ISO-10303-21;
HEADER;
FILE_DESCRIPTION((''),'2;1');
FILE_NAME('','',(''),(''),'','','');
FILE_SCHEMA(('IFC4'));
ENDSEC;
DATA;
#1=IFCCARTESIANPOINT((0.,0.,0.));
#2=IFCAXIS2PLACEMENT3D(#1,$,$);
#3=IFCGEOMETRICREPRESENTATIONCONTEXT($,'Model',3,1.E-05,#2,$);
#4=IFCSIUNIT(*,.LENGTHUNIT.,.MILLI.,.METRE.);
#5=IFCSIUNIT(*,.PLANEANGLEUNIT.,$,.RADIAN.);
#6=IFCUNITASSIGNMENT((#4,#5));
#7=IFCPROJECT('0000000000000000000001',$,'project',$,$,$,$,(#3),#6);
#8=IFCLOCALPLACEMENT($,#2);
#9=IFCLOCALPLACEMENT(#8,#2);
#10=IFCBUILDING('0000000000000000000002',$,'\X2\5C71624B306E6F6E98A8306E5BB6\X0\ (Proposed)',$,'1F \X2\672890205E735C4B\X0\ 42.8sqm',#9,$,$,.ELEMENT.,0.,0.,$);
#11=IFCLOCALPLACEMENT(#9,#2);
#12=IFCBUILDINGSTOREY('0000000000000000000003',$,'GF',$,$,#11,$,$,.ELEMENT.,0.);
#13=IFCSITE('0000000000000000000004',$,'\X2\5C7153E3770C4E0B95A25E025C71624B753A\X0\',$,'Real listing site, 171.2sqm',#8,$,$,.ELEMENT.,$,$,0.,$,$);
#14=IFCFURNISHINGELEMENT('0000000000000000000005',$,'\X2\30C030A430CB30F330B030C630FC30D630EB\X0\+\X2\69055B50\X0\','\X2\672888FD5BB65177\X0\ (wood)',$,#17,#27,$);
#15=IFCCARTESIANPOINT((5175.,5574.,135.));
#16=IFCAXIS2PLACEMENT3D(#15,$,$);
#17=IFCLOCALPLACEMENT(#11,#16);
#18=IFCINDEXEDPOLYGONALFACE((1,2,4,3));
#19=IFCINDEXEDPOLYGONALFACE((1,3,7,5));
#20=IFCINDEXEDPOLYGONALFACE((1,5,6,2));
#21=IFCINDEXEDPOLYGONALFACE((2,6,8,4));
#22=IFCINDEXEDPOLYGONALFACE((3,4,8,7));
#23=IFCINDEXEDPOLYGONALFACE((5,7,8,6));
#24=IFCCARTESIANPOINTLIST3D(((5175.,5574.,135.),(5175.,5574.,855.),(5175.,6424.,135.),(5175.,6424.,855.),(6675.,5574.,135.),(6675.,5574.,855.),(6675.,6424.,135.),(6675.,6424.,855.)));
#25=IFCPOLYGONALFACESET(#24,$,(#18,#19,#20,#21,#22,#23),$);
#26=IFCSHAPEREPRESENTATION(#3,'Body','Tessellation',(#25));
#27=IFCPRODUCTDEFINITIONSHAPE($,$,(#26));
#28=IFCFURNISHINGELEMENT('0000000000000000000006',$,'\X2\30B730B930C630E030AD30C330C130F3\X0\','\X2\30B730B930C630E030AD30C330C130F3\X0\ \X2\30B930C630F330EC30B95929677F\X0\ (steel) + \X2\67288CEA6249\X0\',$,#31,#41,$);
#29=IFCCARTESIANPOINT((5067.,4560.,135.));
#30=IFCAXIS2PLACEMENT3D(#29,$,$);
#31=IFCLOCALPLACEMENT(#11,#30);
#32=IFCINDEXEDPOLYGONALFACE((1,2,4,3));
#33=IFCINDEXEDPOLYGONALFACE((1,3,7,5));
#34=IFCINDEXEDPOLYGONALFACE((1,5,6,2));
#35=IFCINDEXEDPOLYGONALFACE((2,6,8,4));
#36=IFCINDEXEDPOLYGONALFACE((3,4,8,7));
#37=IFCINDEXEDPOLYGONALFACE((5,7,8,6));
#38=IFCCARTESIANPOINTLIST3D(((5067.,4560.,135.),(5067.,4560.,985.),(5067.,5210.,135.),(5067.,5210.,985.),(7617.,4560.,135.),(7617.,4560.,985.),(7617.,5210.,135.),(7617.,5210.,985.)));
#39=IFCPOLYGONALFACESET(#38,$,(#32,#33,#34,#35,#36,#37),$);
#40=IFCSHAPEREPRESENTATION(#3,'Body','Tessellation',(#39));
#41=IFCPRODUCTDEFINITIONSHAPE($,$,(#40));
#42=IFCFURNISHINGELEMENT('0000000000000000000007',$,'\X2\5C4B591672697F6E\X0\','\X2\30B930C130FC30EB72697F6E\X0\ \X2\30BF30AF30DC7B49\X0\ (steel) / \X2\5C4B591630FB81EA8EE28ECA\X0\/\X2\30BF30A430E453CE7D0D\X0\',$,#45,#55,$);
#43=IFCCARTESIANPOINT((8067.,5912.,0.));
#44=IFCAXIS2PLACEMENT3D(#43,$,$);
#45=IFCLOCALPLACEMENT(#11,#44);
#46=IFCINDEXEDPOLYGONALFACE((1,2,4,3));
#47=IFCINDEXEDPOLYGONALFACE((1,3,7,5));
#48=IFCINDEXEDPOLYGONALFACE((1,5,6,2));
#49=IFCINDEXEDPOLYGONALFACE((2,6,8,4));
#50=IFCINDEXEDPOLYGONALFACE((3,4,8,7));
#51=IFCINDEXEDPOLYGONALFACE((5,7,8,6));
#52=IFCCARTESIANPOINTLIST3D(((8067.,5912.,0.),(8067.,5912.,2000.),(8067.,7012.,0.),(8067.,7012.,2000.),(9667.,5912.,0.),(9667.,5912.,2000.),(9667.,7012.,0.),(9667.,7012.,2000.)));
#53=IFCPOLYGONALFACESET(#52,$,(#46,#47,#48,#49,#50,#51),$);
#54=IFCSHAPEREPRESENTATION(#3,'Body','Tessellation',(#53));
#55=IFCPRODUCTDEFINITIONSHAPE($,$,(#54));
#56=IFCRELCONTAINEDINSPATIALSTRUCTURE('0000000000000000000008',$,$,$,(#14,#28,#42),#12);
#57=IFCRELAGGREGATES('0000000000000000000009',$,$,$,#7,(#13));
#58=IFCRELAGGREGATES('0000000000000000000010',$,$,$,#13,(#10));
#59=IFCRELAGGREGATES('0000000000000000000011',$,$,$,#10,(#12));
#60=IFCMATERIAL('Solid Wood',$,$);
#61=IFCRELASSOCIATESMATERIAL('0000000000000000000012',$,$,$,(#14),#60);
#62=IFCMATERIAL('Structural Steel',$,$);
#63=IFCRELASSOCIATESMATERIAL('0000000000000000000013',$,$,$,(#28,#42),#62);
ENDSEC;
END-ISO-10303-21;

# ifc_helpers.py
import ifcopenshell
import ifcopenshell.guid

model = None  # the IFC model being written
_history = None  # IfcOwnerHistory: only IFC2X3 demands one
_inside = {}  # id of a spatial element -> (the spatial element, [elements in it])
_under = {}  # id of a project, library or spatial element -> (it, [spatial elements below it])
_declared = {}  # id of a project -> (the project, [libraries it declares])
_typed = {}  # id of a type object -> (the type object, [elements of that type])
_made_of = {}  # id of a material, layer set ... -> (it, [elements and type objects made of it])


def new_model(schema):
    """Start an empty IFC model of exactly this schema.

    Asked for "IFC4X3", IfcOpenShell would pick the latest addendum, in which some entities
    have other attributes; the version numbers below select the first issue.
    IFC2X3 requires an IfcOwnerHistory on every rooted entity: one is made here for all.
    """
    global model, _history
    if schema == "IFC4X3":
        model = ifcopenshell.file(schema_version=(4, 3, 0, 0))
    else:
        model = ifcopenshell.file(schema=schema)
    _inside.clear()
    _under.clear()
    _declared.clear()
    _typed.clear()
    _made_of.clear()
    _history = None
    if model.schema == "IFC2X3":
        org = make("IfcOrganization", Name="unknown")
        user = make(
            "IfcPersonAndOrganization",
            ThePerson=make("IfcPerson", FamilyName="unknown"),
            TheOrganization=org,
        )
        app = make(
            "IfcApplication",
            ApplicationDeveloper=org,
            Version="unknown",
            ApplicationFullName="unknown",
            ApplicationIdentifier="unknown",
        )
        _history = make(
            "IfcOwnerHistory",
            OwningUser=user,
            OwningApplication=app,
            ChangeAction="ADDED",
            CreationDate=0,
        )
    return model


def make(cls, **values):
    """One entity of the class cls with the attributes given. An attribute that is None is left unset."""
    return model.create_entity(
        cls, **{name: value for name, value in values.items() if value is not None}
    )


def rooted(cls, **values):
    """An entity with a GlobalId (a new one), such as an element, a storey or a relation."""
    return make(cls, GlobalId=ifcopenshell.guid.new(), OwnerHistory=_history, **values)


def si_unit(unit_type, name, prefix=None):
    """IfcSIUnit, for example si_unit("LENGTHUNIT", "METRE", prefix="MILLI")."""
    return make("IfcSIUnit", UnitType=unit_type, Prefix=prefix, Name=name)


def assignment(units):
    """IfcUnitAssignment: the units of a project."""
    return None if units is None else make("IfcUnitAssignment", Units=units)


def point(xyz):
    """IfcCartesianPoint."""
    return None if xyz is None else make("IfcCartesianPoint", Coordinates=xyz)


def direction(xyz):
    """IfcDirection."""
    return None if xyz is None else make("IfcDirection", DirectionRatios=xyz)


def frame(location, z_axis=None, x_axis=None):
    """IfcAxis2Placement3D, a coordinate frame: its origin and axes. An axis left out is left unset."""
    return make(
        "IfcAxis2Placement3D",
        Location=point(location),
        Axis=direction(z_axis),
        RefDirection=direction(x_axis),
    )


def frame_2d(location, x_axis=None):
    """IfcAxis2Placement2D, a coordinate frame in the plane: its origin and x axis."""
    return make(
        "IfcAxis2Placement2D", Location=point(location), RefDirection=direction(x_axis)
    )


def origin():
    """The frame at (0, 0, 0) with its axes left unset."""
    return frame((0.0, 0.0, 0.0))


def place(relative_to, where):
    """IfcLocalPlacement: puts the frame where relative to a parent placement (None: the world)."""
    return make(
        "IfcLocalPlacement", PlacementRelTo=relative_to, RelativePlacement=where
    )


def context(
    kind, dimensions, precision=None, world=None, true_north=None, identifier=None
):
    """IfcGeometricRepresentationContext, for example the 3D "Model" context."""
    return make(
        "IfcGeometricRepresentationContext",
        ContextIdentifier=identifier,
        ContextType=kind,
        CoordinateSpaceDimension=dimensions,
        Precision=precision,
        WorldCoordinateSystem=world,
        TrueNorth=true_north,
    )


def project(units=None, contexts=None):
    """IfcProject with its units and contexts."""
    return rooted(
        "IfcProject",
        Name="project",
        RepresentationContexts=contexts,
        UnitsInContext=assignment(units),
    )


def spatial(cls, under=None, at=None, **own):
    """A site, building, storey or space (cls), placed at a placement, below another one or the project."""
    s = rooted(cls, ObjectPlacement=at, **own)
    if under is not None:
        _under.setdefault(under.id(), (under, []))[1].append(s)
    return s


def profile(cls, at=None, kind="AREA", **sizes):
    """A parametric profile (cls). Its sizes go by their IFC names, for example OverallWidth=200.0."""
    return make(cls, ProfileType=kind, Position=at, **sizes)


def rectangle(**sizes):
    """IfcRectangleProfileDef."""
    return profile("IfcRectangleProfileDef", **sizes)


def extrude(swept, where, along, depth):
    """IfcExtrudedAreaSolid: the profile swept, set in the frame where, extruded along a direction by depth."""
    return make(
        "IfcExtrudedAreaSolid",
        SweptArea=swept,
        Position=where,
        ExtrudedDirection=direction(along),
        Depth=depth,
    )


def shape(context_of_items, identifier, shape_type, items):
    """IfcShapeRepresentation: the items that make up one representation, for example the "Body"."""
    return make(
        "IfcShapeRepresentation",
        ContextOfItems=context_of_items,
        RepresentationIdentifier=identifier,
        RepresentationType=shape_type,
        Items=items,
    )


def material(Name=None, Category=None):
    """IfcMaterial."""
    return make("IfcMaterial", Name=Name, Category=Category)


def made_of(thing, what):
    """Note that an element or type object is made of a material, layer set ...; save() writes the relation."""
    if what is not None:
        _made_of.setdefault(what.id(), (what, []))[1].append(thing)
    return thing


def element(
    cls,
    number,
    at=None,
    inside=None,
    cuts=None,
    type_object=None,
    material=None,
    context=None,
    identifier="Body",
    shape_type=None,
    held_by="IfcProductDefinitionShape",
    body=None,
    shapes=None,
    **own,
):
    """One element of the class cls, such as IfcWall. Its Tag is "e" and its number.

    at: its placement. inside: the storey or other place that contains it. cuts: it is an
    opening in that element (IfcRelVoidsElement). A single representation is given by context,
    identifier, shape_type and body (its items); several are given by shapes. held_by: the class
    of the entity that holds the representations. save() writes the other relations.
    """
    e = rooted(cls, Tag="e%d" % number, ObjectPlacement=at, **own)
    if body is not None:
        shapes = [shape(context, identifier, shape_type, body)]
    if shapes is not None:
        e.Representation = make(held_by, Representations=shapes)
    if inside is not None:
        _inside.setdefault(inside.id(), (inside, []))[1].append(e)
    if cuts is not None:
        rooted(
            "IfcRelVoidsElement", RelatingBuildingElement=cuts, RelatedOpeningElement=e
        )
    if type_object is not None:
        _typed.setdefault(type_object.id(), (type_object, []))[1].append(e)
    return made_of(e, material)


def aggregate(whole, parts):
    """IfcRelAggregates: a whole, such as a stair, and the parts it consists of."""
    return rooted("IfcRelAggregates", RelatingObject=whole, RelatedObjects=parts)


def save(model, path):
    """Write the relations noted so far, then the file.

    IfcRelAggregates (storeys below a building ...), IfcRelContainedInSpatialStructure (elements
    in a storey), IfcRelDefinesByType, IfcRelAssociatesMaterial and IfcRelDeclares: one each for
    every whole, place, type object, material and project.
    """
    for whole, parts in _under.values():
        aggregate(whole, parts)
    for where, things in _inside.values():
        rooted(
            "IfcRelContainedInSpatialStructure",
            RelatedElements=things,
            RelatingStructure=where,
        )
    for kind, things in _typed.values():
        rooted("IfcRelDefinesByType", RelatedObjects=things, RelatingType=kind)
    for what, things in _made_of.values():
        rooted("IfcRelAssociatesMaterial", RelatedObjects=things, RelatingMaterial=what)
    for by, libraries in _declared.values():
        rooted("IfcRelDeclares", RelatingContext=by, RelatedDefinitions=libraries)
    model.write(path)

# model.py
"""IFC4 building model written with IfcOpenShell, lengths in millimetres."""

from ifc_helpers import new_model, si_unit, frame, frame_2d, origin, place, context, project, spatial, rectangle, extrude, material, element, save


model = new_model("IFC4")

# Units and contexts
model_context = context("Model", 3, precision=1e-05, world=origin())
ifc_project = project(units=[si_unit("LENGTHUNIT", "METRE", prefix="MILLI"), si_unit("PLANEANGLEUNIT", "RADIAN")], contexts=[model_context])

# Site, building, storey
site_placement = place(None, origin())
site = spatial("IfcSite", under=ifc_project, at=site_placement, Name="山口県下関市山手町", ObjectType="Real listing site, 171.2sqm", CompositionType="ELEMENT", RefElevation=0.0)
building_placement = place(site_placement, origin())
building = spatial("IfcBuilding", under=site, at=building_placement, Name="山手の潮風の家 (Proposed)", ObjectType="1F 木造平屋 42.8sqm", CompositionType="ELEMENT", ElevationOfRefHeight=0.0, ElevationOfTerrain=0.0)
storey_placement = place(building_placement, origin())
storey = spatial("IfcBuildingStorey", under=building, at=storey_placement, Name="GF", CompositionType="ELEMENT", Elevation=0.0)

# Shared definitions
ifc_material_1 = material(Name="Solid Wood")

# Shared definitions
ifc_material_2 = material(Name="Structural Steel")

# Furnishing elements
furnishing_1_placement = place(storey_placement, frame((5175.0, 5574.0, 135.0)))
element("IfcFurnishingElement", 1, at=furnishing_1_placement, inside=storey, material=ifc_material_1, Name="ダイニングテーブル+椅子", Description="木製家具 (wood)", context=model_context, shape_type="SweptSolid", body=[
    extrude(rectangle(XDim=1500.0, YDim=850.0, at=frame_2d((750.0, 425.0))), frame((5175.0, 5574.0, 135.0)), (0.0, 0.0, 1.0), 720.0),
])
furnishing_2_placement = place(storey_placement, frame((5067.0, 4560.0, 135.0)))
element("IfcFurnishingElement", 2, at=furnishing_2_placement, inside=storey, material=ifc_material_2, Name="システムキッチン", Description="システムキッチン ステンレス天板 (steel) + 木質扉", context=model_context, shape_type="SweptSolid", body=[
    extrude(rectangle(XDim=2550.0, YDim=650.0, at=frame_2d((1275.0, 325.0))), frame((5067.0, 4560.0, 135.0)), (0.0, 0.0, 1.0), 850.0),
])
furnishing_3_placement = place(storey_placement, frame((8067.0, 5912.0, 0.0)))
element("IfcFurnishingElement", 3, at=furnishing_3_placement, inside=storey, material=ifc_material_2, Name="屋外物置", Description="スチール物置 タクボ等 (steel) / 屋外・自転車/タイヤ収納", context=model_context, shape_type="SweptSolid", body=[
    extrude(rectangle(XDim=1600.0, YDim=1100.0, at=frame_2d((800.0, 550.0))), frame((8067.0, 5912.0, 0.0)), (0.0, 0.0, 1.0), 2000.0),
])

save(model, "model.ifc")
